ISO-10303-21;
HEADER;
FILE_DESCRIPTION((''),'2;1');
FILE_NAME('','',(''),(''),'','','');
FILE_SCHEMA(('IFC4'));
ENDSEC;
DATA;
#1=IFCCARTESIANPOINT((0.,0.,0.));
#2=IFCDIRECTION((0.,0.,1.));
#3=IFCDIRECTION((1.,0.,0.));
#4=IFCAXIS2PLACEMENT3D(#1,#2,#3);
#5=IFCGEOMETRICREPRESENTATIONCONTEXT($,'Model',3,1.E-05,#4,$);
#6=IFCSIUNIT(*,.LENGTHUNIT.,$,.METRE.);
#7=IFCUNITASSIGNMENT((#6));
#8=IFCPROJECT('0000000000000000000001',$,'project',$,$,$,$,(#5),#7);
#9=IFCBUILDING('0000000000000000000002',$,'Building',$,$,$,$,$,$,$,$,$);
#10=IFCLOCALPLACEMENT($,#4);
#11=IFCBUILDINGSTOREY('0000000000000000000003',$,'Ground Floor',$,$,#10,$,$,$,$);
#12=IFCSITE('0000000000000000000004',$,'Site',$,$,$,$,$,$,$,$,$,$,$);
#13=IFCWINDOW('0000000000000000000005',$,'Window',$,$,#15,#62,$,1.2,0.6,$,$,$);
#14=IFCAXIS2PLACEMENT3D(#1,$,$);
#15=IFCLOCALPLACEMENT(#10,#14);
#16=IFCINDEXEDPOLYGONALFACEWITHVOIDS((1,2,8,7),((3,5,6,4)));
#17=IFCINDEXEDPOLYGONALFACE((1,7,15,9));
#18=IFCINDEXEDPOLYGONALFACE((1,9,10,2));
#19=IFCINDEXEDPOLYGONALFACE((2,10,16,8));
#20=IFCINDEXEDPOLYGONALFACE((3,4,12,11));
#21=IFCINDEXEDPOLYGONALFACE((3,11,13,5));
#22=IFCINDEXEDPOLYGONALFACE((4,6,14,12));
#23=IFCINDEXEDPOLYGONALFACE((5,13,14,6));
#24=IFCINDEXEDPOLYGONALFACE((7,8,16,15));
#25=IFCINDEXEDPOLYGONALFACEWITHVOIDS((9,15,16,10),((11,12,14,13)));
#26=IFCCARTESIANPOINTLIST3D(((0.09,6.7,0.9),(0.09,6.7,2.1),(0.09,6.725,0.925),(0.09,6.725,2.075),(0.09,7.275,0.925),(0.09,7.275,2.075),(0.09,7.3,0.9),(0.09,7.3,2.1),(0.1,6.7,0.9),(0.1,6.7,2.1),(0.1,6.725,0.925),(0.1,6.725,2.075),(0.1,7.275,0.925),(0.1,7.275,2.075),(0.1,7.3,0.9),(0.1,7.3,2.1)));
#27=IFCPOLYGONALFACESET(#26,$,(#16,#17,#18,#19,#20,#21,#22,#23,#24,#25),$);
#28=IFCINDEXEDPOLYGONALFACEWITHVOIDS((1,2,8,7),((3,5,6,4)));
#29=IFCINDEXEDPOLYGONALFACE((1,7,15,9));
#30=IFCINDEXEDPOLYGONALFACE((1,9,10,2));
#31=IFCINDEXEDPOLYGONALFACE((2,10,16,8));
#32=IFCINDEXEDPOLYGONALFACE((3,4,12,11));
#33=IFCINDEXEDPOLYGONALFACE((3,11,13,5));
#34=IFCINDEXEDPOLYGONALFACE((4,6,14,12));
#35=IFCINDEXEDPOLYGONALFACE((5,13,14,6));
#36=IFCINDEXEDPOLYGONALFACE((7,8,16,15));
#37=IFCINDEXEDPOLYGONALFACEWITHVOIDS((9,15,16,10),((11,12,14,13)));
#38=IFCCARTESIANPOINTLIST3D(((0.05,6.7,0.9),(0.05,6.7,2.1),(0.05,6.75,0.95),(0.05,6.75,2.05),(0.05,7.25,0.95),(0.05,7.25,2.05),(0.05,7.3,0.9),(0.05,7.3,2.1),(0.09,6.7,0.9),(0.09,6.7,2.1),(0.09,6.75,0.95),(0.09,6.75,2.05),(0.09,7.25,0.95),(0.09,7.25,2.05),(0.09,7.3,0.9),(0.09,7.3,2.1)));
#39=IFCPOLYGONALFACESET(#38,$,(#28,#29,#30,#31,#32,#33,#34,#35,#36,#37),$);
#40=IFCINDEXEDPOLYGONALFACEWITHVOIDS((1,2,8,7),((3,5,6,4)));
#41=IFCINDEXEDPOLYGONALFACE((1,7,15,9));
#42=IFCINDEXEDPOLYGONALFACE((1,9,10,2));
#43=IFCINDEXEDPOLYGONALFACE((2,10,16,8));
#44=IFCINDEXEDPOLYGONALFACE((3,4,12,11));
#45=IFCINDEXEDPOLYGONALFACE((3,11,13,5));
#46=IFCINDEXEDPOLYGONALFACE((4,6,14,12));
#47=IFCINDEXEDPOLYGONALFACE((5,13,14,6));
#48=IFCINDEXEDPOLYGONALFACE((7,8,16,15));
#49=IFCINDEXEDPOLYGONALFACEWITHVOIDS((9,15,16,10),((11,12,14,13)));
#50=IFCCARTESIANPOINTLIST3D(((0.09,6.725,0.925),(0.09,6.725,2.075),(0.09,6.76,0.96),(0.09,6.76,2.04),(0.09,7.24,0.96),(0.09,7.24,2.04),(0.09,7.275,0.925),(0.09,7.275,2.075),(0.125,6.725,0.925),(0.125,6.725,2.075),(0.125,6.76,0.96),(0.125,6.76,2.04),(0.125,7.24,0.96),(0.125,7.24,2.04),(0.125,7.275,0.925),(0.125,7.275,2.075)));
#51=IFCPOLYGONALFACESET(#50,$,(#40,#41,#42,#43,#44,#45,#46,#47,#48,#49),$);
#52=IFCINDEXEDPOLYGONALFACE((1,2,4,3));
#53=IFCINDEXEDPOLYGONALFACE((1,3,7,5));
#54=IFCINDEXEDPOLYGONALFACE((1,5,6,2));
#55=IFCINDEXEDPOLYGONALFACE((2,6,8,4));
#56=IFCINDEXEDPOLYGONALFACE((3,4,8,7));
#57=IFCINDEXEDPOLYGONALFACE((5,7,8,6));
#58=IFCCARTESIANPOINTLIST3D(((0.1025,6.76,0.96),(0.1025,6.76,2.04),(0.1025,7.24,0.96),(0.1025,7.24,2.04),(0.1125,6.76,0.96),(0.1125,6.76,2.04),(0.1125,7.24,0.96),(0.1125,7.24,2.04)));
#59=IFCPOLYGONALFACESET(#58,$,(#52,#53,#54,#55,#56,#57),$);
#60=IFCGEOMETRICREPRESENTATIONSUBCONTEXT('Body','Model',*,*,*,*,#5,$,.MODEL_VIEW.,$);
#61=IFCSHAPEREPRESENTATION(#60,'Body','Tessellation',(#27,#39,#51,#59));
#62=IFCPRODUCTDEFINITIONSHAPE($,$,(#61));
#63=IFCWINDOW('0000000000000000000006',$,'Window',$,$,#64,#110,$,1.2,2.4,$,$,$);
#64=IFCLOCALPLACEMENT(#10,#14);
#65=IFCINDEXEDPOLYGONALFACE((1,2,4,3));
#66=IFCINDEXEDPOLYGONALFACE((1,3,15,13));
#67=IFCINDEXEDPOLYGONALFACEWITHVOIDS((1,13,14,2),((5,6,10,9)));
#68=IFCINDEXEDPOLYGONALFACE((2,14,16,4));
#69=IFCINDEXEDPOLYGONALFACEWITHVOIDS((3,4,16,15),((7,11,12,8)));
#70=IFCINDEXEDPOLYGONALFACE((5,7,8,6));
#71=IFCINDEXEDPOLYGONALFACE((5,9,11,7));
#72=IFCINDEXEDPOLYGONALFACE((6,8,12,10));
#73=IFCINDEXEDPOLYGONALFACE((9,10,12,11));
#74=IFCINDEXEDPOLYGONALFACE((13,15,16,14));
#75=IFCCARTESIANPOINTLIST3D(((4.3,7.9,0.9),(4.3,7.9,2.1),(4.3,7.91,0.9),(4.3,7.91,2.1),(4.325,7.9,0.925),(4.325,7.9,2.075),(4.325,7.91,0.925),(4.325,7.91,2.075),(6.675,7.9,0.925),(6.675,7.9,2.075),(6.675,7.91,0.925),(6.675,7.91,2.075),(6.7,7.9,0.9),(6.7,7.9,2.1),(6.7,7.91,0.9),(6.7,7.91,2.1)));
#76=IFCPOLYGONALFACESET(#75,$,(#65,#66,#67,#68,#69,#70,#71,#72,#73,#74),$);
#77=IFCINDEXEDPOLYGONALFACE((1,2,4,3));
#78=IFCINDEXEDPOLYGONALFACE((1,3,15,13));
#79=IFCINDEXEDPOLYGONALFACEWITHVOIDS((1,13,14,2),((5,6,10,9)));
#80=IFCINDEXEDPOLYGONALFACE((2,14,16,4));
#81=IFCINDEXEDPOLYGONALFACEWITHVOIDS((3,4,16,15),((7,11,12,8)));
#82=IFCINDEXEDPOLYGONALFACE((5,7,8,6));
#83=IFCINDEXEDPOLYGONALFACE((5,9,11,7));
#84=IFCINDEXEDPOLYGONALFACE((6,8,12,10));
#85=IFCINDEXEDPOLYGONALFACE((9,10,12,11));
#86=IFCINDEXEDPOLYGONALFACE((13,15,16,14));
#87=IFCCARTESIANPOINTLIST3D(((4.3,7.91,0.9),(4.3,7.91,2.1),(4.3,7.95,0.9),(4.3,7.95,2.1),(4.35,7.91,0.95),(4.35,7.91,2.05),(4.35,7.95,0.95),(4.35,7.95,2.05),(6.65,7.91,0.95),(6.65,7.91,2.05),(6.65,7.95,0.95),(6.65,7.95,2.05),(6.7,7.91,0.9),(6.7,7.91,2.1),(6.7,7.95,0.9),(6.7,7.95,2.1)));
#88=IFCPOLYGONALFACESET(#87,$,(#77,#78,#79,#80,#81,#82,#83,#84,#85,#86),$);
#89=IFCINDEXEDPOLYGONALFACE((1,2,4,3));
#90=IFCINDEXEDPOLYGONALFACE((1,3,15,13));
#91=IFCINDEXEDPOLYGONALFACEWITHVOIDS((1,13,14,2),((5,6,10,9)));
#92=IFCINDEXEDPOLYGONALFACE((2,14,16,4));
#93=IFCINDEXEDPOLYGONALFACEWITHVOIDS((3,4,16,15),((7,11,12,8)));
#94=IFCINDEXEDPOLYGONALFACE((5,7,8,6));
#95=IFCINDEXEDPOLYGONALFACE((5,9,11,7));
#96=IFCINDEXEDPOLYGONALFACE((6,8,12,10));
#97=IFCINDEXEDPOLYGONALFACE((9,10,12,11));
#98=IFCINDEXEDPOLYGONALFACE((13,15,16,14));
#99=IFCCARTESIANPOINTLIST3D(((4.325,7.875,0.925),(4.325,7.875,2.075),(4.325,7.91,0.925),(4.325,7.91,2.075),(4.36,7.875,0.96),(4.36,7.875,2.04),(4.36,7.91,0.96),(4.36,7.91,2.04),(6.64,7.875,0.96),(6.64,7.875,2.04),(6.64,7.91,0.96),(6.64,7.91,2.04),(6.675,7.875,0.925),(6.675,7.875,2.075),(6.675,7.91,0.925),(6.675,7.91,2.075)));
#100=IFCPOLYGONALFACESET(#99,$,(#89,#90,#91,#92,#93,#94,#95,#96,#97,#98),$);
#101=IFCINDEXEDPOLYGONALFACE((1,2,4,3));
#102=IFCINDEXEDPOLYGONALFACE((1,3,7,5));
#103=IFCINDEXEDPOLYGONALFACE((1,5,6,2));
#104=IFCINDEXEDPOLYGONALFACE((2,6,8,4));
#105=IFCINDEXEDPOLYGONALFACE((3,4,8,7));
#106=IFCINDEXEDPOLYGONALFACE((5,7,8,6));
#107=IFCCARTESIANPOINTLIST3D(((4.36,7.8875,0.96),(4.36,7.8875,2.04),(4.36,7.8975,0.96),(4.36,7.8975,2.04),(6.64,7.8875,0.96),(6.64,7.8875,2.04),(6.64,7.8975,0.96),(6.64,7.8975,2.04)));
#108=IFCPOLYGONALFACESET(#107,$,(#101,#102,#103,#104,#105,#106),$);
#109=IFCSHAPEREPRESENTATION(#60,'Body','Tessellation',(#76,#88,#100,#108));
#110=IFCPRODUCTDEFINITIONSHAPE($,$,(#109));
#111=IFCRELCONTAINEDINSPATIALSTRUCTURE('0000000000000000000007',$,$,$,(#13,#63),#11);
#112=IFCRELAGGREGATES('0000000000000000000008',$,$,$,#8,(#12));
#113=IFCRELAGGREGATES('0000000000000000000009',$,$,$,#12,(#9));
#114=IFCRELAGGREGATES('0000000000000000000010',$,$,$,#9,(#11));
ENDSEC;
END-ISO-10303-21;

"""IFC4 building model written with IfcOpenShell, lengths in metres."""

from ifc_helpers import new_model, si_unit, frame, origin_with_axes, place, context, subcontext, project, spatial, line, indexed_curve, outline, extrude, element, save


model = new_model("IFC4")

# Units and contexts
model_context = context("Model", 3, precision=1e-05, world=origin_with_axes())
body_context = subcontext(model_context, "Body", "Model", "MODEL_VIEW")
ifc_project = project(units=[si_unit("LENGTHUNIT", "METRE")], contexts=[model_context])

# Site, building, storey
site = spatial("IfcSite", under=ifc_project, Name="Site")
building = spatial("IfcBuilding", under=site, Name="Building")
storey_placement = place(None, origin_with_axes())
storey = spatial("IfcBuildingStorey", under=building, at=storey_placement, Name="Ground Floor")

# Windows
window_1_placement = place(storey_placement, frame((0.0, 7.3, 0.9), z_axis=(0.0, 0.0, 1.0), x_axis=(0.0, -1.0, 0.0)))
element("IfcWindow", 1, at=window_1_placement, inside=storey, Name="Window", OverallHeight=1.2, OverallWidth=0.6, context=body_context, shape_type="SweptSolid", body=[
    extrude(outline(indexed_curve([(0.0, 0.0), (0.6, 0.0), (0.6, 1.2), (0.0, 1.2)], segments=[line(1, 2, 3, 4, 1)]), holes=[indexed_curve([(0.025, 0.025), (0.575, 0.025), (0.575, 1.175), (0.025, 1.175)], segments=[line(1, 2, 3, 4, 1)])]), frame((0.0, 0.09, 0.0), z_axis=(0.0, -1.0, 0.0), x_axis=(1.0, 0.0, 0.0)), (0.0, 0.0, -1.0), 0.01),
    extrude(outline(indexed_curve([(0.0, 0.0), (0.6, 0.0), (0.6, 1.2), (0.0, 1.2)], segments=[line(1, 2, 3, 4, 1)]), holes=[indexed_curve([(0.05, 0.05), (0.55, 0.05), (0.55, 1.15), (0.05, 1.15)], segments=[line(1, 2, 3, 4, 1)])]), frame((0.0, 0.05, 0.0), z_axis=(0.0, -1.0, 0.0), x_axis=(1.0, 0.0, 0.0)), (0.0, 0.0, -1.0), 0.04),
    extrude(outline(indexed_curve([(0.0, 0.0), (0.55, 0.0), (0.55, 1.15), (0.0, 1.15)], segments=[line(1, 2, 3, 4, 1)]), holes=[indexed_curve([(0.035, 0.035), (0.515, 0.035), (0.515, 1.115), (0.035, 1.115)], segments=[line(1, 2, 3, 4, 1)])]), frame((0.025, 0.09, 0.025), z_axis=(0.0, -1.0, 0.0), x_axis=(1.0, 0.0, 0.0)), (0.0, 0.0, -1.0), 0.035),
    extrude(outline(indexed_curve([(0.035, 0.035), (0.515, 0.035), (0.515, 1.115), (0.035, 1.115)], segments=[line(1, 2, 3, 4, 1)])), frame((0.025, 0.1025, 0.025), z_axis=(0.0, -1.0, 0.0), x_axis=(1.0, 0.0, 0.0)), (0.0, 0.0, -1.0), 0.01),
])
window_2_placement = place(storey_placement, frame((6.7, 8.0, 0.9), z_axis=(0.0, 0.0, 1.0), x_axis=(-1.0, 0.0, 0.0)))
element("IfcWindow", 2, at=window_2_placement, inside=storey, Name="Window", OverallHeight=1.2, OverallWidth=2.4, context=body_context, shape_type="SweptSolid", body=[
    extrude(outline(indexed_curve([(0.0, 0.0), (2.4, 0.0), (2.4, 1.2), (0.0, 1.2)], segments=[line(1, 2, 3, 4, 1)]), holes=[indexed_curve([(0.025, 0.025), (2.375, 0.025), (2.375, 1.175), (0.025, 1.175)], segments=[line(1, 2, 3, 4, 1)])]), frame((0.0, 0.09, 0.0), z_axis=(0.0, -1.0, 0.0), x_axis=(1.0, 0.0, 0.0)), (0.0, 0.0, -1.0), 0.01),
    extrude(outline(indexed_curve([(0.0, 0.0), (2.4, 0.0), (2.4, 1.2), (0.0, 1.2)], segments=[line(1, 2, 3, 4, 1)]), holes=[indexed_curve([(0.05, 0.05), (2.35, 0.05), (2.35, 1.15), (0.05, 1.15)], segments=[line(1, 2, 3, 4, 1)])]), frame((0.0, 0.05, 0.0), z_axis=(0.0, -1.0, 0.0), x_axis=(1.0, 0.0, 0.0)), (0.0, 0.0, -1.0), 0.04),
    extrude(outline(indexed_curve([(0.0, 0.0), (2.35, 0.0), (2.35, 1.15), (0.0, 1.15)], segments=[line(1, 2, 3, 4, 1)]), holes=[indexed_curve([(0.035, 0.035), (2.315, 0.035), (2.315, 1.115), (0.035, 1.115)], segments=[line(1, 2, 3, 4, 1)])]), frame((0.025, 0.09, 0.025), z_axis=(0.0, -1.0, 0.0), x_axis=(1.0, 0.0, 0.0)), (0.0, 0.0, -1.0), 0.035),
    extrude(outline(indexed_curve([(0.035, 0.035), (2.315, 0.035), (2.315, 1.115), (0.035, 1.115)], segments=[line(1, 2, 3, 4, 1)])), frame((0.025, 0.1025, 0.025), z_axis=(0.0, -1.0, 0.0), x_axis=(1.0, 0.0, 0.0)), (0.0, 0.0, -1.0), 0.01),
])

save(model, "model.ifc")
